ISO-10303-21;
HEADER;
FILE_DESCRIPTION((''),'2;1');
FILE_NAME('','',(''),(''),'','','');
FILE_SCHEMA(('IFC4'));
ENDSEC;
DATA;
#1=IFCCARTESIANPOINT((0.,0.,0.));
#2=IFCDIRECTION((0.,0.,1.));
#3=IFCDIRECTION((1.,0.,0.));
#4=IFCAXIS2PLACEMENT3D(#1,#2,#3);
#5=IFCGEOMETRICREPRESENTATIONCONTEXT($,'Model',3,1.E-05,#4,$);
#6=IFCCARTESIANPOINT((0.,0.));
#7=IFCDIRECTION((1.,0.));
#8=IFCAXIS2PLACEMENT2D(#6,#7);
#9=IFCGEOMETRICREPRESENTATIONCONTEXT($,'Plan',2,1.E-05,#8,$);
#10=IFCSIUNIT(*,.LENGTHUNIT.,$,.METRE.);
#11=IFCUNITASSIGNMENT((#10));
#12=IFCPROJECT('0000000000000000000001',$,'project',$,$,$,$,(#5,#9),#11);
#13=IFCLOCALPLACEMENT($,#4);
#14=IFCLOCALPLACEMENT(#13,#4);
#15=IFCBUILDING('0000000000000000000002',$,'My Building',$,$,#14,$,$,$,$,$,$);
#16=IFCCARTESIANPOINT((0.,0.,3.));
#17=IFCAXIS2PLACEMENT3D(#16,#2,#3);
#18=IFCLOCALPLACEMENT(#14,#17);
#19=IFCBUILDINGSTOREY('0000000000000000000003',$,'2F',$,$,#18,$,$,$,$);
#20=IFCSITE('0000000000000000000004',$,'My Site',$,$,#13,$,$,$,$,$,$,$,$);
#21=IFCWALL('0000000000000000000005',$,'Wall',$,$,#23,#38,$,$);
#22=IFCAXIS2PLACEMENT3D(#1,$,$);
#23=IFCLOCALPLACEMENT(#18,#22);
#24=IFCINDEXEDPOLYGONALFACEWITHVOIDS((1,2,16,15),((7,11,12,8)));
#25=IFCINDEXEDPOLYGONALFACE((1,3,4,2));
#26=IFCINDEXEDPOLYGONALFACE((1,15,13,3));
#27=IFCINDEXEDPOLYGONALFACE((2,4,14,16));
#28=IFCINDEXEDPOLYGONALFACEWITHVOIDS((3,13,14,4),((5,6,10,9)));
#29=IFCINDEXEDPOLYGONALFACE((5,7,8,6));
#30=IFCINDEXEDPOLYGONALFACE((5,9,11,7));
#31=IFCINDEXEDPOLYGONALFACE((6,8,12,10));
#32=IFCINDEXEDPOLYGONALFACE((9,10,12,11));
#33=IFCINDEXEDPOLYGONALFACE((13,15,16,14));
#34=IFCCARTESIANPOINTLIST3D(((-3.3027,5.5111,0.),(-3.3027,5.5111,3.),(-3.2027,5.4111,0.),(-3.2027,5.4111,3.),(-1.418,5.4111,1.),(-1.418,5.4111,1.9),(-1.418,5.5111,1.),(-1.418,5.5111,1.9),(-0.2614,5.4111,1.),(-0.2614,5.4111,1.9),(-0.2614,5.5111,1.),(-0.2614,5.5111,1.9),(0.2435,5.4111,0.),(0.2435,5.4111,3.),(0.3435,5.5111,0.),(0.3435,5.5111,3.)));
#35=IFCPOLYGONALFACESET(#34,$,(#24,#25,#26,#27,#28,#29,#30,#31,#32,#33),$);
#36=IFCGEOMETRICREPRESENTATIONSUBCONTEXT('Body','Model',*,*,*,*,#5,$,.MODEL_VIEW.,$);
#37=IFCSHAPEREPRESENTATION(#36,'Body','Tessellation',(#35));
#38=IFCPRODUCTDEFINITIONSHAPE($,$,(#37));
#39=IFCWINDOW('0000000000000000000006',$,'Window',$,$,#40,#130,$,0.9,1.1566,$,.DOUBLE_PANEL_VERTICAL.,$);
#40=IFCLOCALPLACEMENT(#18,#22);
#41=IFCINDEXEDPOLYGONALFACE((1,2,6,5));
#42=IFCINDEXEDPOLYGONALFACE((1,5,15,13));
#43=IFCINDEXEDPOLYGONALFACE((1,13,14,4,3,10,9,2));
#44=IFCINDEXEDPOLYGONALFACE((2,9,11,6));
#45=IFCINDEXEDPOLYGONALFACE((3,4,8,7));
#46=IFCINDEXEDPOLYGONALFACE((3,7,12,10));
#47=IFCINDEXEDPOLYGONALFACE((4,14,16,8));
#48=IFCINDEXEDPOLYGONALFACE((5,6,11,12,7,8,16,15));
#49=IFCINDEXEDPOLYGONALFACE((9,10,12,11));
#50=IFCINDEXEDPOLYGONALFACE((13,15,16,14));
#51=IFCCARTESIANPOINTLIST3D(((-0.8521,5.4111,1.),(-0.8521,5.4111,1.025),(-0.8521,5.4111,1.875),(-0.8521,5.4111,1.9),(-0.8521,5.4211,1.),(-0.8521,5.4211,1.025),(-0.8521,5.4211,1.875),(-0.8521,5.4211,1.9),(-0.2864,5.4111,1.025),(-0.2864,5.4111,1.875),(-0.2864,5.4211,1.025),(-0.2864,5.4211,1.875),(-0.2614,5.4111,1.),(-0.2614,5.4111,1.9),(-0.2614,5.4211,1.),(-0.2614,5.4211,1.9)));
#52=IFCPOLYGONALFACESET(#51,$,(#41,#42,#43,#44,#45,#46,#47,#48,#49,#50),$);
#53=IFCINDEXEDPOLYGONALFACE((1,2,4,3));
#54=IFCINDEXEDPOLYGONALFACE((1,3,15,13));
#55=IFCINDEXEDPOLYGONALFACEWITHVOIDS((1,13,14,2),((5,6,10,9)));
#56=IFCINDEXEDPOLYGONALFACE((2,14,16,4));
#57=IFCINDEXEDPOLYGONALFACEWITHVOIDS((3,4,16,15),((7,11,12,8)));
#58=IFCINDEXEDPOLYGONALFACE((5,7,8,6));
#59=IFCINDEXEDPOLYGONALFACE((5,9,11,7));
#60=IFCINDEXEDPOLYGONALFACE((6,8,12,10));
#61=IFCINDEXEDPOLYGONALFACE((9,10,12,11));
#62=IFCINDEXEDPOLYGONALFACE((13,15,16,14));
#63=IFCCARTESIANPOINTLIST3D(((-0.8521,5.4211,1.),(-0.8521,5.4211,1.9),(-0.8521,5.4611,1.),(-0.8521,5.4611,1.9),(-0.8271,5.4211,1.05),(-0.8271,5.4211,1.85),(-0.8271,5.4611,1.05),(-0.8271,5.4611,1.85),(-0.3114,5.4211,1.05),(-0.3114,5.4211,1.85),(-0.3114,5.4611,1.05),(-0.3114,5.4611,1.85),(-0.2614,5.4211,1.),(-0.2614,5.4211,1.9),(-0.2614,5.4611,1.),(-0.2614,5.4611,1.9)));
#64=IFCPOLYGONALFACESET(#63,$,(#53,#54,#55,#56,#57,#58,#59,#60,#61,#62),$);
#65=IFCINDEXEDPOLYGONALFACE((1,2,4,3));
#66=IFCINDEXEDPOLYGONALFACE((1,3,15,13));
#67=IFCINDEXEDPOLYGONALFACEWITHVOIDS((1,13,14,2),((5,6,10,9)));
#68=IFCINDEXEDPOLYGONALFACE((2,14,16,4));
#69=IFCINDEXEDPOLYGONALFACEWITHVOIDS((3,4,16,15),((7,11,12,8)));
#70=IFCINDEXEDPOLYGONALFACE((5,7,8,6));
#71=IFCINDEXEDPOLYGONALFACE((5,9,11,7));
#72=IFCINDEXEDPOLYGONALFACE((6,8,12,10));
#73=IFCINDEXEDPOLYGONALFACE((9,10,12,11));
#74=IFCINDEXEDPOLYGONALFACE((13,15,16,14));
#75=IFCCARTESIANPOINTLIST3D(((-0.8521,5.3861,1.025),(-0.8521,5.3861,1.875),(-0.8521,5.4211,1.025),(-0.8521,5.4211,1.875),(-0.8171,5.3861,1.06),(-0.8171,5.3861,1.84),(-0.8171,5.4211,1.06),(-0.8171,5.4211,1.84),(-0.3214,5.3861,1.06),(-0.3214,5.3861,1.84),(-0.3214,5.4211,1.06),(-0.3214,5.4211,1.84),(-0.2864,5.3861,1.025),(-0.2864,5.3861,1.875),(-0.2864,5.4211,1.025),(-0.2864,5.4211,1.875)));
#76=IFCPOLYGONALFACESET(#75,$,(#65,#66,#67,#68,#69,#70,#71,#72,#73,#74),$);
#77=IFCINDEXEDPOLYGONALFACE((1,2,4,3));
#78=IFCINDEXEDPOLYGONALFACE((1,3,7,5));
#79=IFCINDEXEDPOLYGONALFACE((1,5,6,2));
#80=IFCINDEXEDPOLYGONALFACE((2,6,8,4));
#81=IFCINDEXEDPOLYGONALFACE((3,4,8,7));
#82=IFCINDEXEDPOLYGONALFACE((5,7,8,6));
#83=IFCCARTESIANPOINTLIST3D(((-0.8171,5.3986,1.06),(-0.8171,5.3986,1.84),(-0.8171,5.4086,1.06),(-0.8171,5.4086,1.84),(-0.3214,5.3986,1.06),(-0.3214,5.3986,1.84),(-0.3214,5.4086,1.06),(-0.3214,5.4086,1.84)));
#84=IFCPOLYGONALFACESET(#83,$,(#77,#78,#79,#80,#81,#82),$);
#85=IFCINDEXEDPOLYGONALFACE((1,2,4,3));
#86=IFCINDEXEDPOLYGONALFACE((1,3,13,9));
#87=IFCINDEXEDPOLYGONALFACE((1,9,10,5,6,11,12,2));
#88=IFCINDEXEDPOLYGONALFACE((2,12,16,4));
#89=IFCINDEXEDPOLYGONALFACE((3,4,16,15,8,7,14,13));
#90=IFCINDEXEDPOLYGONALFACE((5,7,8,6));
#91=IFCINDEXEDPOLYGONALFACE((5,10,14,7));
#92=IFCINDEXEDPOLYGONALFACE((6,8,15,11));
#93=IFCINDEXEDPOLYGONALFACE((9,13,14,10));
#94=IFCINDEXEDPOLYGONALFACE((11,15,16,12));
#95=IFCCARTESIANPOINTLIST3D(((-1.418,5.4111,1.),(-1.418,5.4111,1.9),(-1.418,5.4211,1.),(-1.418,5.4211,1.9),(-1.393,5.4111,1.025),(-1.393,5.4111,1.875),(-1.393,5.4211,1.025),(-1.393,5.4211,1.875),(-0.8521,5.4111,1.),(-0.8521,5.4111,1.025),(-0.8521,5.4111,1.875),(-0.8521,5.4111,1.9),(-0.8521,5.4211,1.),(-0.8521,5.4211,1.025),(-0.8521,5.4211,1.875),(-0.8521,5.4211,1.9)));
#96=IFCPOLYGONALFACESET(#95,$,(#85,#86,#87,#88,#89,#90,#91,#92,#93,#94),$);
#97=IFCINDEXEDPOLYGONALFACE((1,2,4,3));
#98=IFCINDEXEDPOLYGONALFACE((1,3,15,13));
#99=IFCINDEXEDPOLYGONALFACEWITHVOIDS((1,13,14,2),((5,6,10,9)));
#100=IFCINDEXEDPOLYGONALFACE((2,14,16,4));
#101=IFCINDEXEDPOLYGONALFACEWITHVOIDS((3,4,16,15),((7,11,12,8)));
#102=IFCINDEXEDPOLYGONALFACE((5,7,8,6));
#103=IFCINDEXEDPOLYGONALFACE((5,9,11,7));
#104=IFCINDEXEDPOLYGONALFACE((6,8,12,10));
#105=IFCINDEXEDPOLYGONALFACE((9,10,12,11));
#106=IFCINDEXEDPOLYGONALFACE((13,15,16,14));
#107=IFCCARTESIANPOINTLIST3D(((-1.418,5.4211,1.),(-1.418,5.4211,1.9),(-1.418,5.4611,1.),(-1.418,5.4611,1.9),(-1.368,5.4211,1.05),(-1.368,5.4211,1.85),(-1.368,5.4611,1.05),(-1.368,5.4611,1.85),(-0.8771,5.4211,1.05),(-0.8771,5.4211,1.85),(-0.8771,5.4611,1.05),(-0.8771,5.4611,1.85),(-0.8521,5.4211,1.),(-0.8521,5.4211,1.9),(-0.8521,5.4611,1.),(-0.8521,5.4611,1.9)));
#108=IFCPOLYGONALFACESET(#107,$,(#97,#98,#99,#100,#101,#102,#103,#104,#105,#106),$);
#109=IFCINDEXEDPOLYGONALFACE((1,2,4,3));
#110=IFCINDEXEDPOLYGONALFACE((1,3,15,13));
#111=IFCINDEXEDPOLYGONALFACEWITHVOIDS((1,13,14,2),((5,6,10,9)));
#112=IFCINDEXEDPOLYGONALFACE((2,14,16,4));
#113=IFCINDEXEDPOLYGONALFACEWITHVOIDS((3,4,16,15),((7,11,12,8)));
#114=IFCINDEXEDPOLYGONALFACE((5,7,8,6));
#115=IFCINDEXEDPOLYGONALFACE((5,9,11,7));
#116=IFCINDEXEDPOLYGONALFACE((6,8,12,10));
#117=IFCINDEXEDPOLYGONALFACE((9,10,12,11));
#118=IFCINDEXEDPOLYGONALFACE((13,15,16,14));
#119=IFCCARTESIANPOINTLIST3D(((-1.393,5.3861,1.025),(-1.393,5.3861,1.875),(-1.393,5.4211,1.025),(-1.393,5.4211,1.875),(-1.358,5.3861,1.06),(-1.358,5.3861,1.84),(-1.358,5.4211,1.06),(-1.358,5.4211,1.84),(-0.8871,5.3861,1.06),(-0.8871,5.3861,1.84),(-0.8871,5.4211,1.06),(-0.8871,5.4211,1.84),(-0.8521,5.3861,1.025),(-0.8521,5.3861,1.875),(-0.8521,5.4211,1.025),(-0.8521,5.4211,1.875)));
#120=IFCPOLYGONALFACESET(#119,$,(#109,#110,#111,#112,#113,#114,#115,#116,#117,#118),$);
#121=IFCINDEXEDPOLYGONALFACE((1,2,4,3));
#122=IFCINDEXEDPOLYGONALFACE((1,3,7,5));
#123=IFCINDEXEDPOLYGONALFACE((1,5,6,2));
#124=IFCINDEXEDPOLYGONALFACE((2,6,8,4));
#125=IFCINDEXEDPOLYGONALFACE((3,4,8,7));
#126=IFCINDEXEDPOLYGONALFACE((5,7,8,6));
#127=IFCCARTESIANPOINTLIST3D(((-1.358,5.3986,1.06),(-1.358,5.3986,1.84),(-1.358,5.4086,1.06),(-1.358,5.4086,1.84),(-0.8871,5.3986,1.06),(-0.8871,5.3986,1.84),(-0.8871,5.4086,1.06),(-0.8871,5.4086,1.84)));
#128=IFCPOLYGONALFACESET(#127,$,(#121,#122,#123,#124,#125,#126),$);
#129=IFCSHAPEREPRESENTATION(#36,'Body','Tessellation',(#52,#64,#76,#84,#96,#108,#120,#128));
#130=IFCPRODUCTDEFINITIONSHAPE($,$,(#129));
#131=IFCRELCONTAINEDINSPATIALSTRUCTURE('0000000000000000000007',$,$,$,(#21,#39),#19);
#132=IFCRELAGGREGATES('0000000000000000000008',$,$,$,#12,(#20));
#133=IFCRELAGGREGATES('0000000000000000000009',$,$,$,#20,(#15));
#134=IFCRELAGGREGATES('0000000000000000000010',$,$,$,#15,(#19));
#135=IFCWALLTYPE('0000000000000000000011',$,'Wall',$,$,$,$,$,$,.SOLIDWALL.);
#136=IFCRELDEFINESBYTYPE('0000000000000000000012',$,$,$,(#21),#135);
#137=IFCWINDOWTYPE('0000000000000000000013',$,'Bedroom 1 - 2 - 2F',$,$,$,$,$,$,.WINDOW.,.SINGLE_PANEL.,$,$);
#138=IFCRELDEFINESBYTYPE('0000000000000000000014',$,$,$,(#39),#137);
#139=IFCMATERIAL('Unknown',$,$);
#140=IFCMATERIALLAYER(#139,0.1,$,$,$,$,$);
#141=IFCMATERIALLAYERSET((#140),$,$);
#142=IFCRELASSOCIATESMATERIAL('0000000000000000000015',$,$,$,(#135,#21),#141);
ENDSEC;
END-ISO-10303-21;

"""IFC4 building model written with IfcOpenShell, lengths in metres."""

from ifc_helpers import new_model, entity, si_unit, frame, origin_with_axes, origin_2d_with_axis, place, context, subcontext, project, spatial, line, indexed_curve, outline, extrude, shape, source, transform, mapped, material, layer, layer_set, layer_usage, type_object, type_shapes, element, fill, save


model = new_model("IFC4")

# Units and contexts
model_context = context("Model", 3, precision=1e-05, world=origin_with_axes())
plan_context = context("Plan", 2, precision=1e-05, world=origin_2d_with_axis())
body_context_1 = subcontext(model_context, "Body", "Model", "MODEL_VIEW")
body_context_2 = subcontext(plan_context, "Body", "Plan", "PLAN_VIEW")
ifc_project = project(units=[si_unit("LENGTHUNIT", "METRE")], contexts=[model_context, plan_context])

# Site, building, storey
site_placement = place(None, origin_with_axes())
site = spatial("IfcSite", under=ifc_project, at=site_placement, Name="My Site")
building_placement = place(site_placement, origin_with_axes())
building = spatial("IfcBuilding", under=site, at=building_placement, Name="My Building")
storey_placement = place(building_placement, frame((0.0, 0.0, 3.0), z_axis=(0.0, 0.0, 1.0), x_axis=(1.0, 0.0, 0.0)))
storey = spatial("IfcBuildingStorey", under=building, at=storey_placement, Name="2F")

# Shared definitions
ifc_material = material(Name="Unknown")

# Shared definitions
ifc_layer = layer(ifc_material, 0.1)
ifc_layer_set = layer_set([ifc_layer])
wall_type = type_object("IfcWallType", Name="Wall", PredefinedType="SOLIDWALL", material=ifc_layer_set)

# Wall, opening, window
ifc_layer_usage_1 = layer_usage(ifc_layer_set, "AXIS2", "POSITIVE", 0.0)
wall_1_placement = place(storey_placement, frame((0.3435, 5.5111, 0.0), z_axis=(0.0, 0.0, 1.0), x_axis=(-1.0, 0.0, 0.0)))
wall_1 = element("IfcWall", 1, at=wall_1_placement, inside=storey, type_object=wall_type, material=ifc_layer_usage_1, Name="Wall", context=body_context_1, shape_type="SweptSolid", body=[
    extrude(outline(indexed_curve([(0.0, 0.0), (0.1, 0.1), (3.5462, 0.1), (3.6462, 0.0)], segments=[line(1, 2, 3, 4, 1)])), origin_with_axes(), (0.0, 0.0, 1.0), 3.0),
])
shared_shape_1 = source(origin_with_axes(), body_context_1, "Body", "SweptSolid", [
    extrude(outline(indexed_curve([(0.0, 0.0), (1.1566, 0.0), (1.1566, 0.9), (0.0, 0.9)], segments=[line(1, 2, 3, 4, 1)])), frame((0.0, -0.6, 0.0), z_axis=(0.0, -1.0, 0.0), x_axis=(1.0, 0.0, 0.0)), (0.0, 0.0, -1.0), 1.2),
])
opening_1_placement = place(wall_1_placement, frame((0.6048, 0.0, 1.0), z_axis=(0.0, 0.0, 1.0), x_axis=(1.0, 0.0, 0.0)))
opening_1 = element("IfcOpeningElement", 2, at=opening_1_placement, cuts=wall_1, PredefinedType="OPENING", context=body_context_1, shape_type="MappedRepresentation", body=[
    mapped(shared_shape_1, transform((0.0, 0.0, 0.0), x_axis=(1.0, 0.0, 0.0), y_axis=(0.0, 1.0, 0.0), z_axis=(0.0, 0.0, 1.0), scale=1.0)),
])
window_type_1 = type_object("IfcWindowType", Name="Bedroom 1 - 2 - 2F", PartitioningType="SINGLE_PANEL", PredefinedType="WINDOW")
shared_shape_2 = source(origin_with_axes(), body_context_1, "Body", "SweptSolid", [
    extrude(outline(indexed_curve([(0.5908, 0.0), (0.0, 0.0), (0.0, 0.9), (0.5908, 0.9), (0.5908, 0.875), (0.025, 0.875), (0.025, 0.025), (0.5908, 0.025)], segments=[line(1, 2, 3, 4, 5, 6, 7, 8, 1)])), frame((0.0, 0.09, 0.0), z_axis=(0.0, -1.0, 0.0), x_axis=(1.0, 0.0, 0.0)), (0.0, 0.0, -1.0), 0.01),
    extrude(outline(indexed_curve([(0.0, 0.0), (0.5908, 0.0), (0.5908, 0.9), (0.0, 0.9)], segments=[line(1, 2, 3, 4, 1)]), holes=[indexed_curve([(0.05, 0.05), (0.5658, 0.05), (0.5658, 0.85), (0.05, 0.85)], segments=[line(1, 2, 3, 4, 1)])]), frame((0.0, 0.05, 0.0), z_axis=(0.0, -1.0, 0.0), x_axis=(1.0, 0.0, 0.0)), (0.0, 0.0, -1.0), 0.04),
    extrude(outline(indexed_curve([(0.0, 0.0), (0.5658, 0.0), (0.5658, 0.85), (0.0, 0.85)], segments=[line(1, 2, 3, 4, 1)]), holes=[indexed_curve([(0.035, 0.035), (0.5308, 0.035), (0.5308, 0.815), (0.035, 0.815)], segments=[line(1, 2, 3, 4, 1)])]), frame((0.025, 0.09, 0.025), z_axis=(0.0, -1.0, 0.0), x_axis=(1.0, 0.0, 0.0)), (0.0, 0.0, -1.0), 0.035),
    extrude(outline(indexed_curve([(0.035, 0.035), (0.5308, 0.035), (0.5308, 0.815), (0.035, 0.815)], segments=[line(1, 2, 3, 4, 1)])), frame((0.025, 0.1025, 0.025), z_axis=(0.0, -1.0, 0.0), x_axis=(1.0, 0.0, 0.0)), (0.0, 0.0, -1.0), 0.01),
    extrude(outline(indexed_curve([(0.0, 0.9), (0.5659, 0.9), (0.5659, 0.0), (0.0, 0.0), (0.0, 0.025), (0.5409, 0.025), (0.5409, 0.875), (0.0, 0.875)], segments=[line(1, 2, 3, 4, 5, 6, 7, 8, 1)])), frame((0.5908, 0.09, 0.0), z_axis=(0.0, -1.0, 0.0), x_axis=(1.0, 0.0, 0.0)), (0.0, 0.0, -1.0), 0.01),
    extrude(outline(indexed_curve([(0.0, 0.0), (0.5659, 0.0), (0.5659, 0.9), (0.0, 0.9)], segments=[line(1, 2, 3, 4, 1)]), holes=[indexed_curve([(0.025, 0.05), (0.5159, 0.05), (0.5159, 0.85), (0.025, 0.85)], segments=[line(1, 2, 3, 4, 1)])]), frame((0.5908, 0.05, 0.0), z_axis=(0.0, -1.0, 0.0), x_axis=(1.0, 0.0, 0.0)), (0.0, 0.0, -1.0), 0.04),
    extrude(outline(indexed_curve([(0.0, 0.0), (0.5409, 0.0), (0.5409, 0.85), (0.0, 0.85)], segments=[line(1, 2, 3, 4, 1)]), holes=[indexed_curve([(0.035, 0.035), (0.5059, 0.035), (0.5059, 0.815), (0.035, 0.815)], segments=[line(1, 2, 3, 4, 1)])]), frame((0.5908, 0.09, 0.025), z_axis=(0.0, -1.0, 0.0), x_axis=(1.0, 0.0, 0.0)), (0.0, 0.0, -1.0), 0.035),
    extrude(outline(indexed_curve([(0.035, 0.035), (0.5059, 0.035), (0.5059, 0.815), (0.035, 0.815)], segments=[line(1, 2, 3, 4, 1)])), frame((0.5908, 0.1025, 0.025), z_axis=(0.0, -1.0, 0.0), x_axis=(1.0, 0.0, 0.0)), (0.0, 0.0, -1.0), 0.01),
])
shared_shape_3 = source(origin_with_axes(), body_context_2, "Body", "Curve2D", [
    entity("IfcIndexedPolyCurve", entity("IfcCartesianPointList2D", [[0.05, 0.05], [0.5658, 0.05]])),
    entity("IfcIndexedPolyCurve", entity("IfcCartesianPointList2D", [[0.0, 0.1], [0.025, 0.1], [0.025, 0.09], [0.05, 0.09], [0.05, 0.05], [0.0, 0.05]]), [entity("IfcLineIndex", [1, 2, 3, 4, 5, 6, 1])]),
    entity("IfcIndexedPolyCurve", entity("IfcCartesianPointList2D", [[0.5908, 0.1], [0.5908, 0.1], [0.5908, 0.09], [0.5658, 0.09], [0.5658, 0.05], [0.5908, 0.05]])),
    entity("IfcIndexedPolyCurve", entity("IfcCartesianPointList2D", [[0.025, 0.09], [0.06, 0.09], [0.06, 0.125], [0.025, 0.125]]), [entity("IfcLineIndex", [1, 2, 3, 4, 1])]),
    entity("IfcIndexedPolyCurve", entity("IfcCartesianPointList2D", [[0.5908, 0.09], [0.5558, 0.09], [0.5558, 0.125], [0.5908, 0.125]]), [entity("IfcLineIndex", [1, 2, 3, 4, 1])]),
    entity("IfcIndexedPolyCurve", entity("IfcCartesianPointList2D", [[0.06, 0.09], [0.5558, 0.09]])),
    entity("IfcIndexedPolyCurve", entity("IfcCartesianPointList2D", [[0.06, 0.125], [0.5558, 0.125]])),
    entity("IfcIndexedPolyCurve", entity("IfcCartesianPointList2D", [[0.06, 0.1075], [0.5558, 0.1075]])),
    entity("IfcIndexedPolyCurve", entity("IfcCartesianPointList2D", [[0.6158, 0.05], [1.1066, 0.05]])),
    entity("IfcIndexedPolyCurve", entity("IfcCartesianPointList2D", [[0.5908, 0.1], [0.5908, 0.1], [0.5908, 0.09], [0.6158, 0.09], [0.6158, 0.05], [0.5908, 0.05]])),
    entity("IfcIndexedPolyCurve", entity("IfcCartesianPointList2D", [[1.1566, 0.1], [1.1316, 0.1], [1.1316, 0.09], [1.1066, 0.09], [1.1066, 0.05], [1.1566, 0.05]]), [entity("IfcLineIndex", [1, 2, 3, 4, 5, 6, 1])]),
    entity("IfcIndexedPolyCurve", entity("IfcCartesianPointList2D", [[0.5908, 0.09], [0.6258, 0.09], [0.6258, 0.125], [0.5908, 0.125]]), [entity("IfcLineIndex", [1, 2, 3, 4, 1])]),
    entity("IfcIndexedPolyCurve", entity("IfcCartesianPointList2D", [[1.1316, 0.09], [1.0966, 0.09], [1.0966, 0.125], [1.1316, 0.125]]), [entity("IfcLineIndex", [1, 2, 3, 4, 1])]),
    entity("IfcIndexedPolyCurve", entity("IfcCartesianPointList2D", [[0.6258, 0.09], [1.0966, 0.09]])),
    entity("IfcIndexedPolyCurve", entity("IfcCartesianPointList2D", [[0.6258, 0.125], [1.0966, 0.125]])),
    entity("IfcIndexedPolyCurve", entity("IfcCartesianPointList2D", [[0.6258, 0.1075], [1.0966, 0.1075]])),
])
type_shapes(window_type_1, [shared_shape_2, shared_shape_3])
window_1_placement = place(opening_1_placement, frame((0.0, 0.0, 0.0), z_axis=(0.0, 0.0, 1.0), x_axis=(1.0, 0.0, 0.0)))
window_1 = element("IfcWindow", 3, at=window_1_placement, inside=storey, type_object=window_type_1, Name="Window", OverallHeight=0.9, OverallWidth=1.1566, PartitioningType="DOUBLE_PANEL_VERTICAL", shapes=[
    shape(body_context_1, "Body", "MappedRepresentation", [mapped(shared_shape_2, transform((0.0, 0.0, 0.0), x_axis=(1.0, 0.0, 0.0), y_axis=(0.0, 1.0, 0.0), z_axis=(0.0, 0.0, 1.0), scale=1.0))]),
    shape(body_context_2, "Body", "MappedRepresentation", [mapped(shared_shape_3, transform((0.0, 0.0, 0.0), x_axis=(1.0, 0.0, 0.0), y_axis=(0.0, 1.0, 0.0), z_axis=(0.0, 0.0, 1.0), scale=1.0))]),
])
fill(opening_1, window_1)

save(model, "model.ifc")
